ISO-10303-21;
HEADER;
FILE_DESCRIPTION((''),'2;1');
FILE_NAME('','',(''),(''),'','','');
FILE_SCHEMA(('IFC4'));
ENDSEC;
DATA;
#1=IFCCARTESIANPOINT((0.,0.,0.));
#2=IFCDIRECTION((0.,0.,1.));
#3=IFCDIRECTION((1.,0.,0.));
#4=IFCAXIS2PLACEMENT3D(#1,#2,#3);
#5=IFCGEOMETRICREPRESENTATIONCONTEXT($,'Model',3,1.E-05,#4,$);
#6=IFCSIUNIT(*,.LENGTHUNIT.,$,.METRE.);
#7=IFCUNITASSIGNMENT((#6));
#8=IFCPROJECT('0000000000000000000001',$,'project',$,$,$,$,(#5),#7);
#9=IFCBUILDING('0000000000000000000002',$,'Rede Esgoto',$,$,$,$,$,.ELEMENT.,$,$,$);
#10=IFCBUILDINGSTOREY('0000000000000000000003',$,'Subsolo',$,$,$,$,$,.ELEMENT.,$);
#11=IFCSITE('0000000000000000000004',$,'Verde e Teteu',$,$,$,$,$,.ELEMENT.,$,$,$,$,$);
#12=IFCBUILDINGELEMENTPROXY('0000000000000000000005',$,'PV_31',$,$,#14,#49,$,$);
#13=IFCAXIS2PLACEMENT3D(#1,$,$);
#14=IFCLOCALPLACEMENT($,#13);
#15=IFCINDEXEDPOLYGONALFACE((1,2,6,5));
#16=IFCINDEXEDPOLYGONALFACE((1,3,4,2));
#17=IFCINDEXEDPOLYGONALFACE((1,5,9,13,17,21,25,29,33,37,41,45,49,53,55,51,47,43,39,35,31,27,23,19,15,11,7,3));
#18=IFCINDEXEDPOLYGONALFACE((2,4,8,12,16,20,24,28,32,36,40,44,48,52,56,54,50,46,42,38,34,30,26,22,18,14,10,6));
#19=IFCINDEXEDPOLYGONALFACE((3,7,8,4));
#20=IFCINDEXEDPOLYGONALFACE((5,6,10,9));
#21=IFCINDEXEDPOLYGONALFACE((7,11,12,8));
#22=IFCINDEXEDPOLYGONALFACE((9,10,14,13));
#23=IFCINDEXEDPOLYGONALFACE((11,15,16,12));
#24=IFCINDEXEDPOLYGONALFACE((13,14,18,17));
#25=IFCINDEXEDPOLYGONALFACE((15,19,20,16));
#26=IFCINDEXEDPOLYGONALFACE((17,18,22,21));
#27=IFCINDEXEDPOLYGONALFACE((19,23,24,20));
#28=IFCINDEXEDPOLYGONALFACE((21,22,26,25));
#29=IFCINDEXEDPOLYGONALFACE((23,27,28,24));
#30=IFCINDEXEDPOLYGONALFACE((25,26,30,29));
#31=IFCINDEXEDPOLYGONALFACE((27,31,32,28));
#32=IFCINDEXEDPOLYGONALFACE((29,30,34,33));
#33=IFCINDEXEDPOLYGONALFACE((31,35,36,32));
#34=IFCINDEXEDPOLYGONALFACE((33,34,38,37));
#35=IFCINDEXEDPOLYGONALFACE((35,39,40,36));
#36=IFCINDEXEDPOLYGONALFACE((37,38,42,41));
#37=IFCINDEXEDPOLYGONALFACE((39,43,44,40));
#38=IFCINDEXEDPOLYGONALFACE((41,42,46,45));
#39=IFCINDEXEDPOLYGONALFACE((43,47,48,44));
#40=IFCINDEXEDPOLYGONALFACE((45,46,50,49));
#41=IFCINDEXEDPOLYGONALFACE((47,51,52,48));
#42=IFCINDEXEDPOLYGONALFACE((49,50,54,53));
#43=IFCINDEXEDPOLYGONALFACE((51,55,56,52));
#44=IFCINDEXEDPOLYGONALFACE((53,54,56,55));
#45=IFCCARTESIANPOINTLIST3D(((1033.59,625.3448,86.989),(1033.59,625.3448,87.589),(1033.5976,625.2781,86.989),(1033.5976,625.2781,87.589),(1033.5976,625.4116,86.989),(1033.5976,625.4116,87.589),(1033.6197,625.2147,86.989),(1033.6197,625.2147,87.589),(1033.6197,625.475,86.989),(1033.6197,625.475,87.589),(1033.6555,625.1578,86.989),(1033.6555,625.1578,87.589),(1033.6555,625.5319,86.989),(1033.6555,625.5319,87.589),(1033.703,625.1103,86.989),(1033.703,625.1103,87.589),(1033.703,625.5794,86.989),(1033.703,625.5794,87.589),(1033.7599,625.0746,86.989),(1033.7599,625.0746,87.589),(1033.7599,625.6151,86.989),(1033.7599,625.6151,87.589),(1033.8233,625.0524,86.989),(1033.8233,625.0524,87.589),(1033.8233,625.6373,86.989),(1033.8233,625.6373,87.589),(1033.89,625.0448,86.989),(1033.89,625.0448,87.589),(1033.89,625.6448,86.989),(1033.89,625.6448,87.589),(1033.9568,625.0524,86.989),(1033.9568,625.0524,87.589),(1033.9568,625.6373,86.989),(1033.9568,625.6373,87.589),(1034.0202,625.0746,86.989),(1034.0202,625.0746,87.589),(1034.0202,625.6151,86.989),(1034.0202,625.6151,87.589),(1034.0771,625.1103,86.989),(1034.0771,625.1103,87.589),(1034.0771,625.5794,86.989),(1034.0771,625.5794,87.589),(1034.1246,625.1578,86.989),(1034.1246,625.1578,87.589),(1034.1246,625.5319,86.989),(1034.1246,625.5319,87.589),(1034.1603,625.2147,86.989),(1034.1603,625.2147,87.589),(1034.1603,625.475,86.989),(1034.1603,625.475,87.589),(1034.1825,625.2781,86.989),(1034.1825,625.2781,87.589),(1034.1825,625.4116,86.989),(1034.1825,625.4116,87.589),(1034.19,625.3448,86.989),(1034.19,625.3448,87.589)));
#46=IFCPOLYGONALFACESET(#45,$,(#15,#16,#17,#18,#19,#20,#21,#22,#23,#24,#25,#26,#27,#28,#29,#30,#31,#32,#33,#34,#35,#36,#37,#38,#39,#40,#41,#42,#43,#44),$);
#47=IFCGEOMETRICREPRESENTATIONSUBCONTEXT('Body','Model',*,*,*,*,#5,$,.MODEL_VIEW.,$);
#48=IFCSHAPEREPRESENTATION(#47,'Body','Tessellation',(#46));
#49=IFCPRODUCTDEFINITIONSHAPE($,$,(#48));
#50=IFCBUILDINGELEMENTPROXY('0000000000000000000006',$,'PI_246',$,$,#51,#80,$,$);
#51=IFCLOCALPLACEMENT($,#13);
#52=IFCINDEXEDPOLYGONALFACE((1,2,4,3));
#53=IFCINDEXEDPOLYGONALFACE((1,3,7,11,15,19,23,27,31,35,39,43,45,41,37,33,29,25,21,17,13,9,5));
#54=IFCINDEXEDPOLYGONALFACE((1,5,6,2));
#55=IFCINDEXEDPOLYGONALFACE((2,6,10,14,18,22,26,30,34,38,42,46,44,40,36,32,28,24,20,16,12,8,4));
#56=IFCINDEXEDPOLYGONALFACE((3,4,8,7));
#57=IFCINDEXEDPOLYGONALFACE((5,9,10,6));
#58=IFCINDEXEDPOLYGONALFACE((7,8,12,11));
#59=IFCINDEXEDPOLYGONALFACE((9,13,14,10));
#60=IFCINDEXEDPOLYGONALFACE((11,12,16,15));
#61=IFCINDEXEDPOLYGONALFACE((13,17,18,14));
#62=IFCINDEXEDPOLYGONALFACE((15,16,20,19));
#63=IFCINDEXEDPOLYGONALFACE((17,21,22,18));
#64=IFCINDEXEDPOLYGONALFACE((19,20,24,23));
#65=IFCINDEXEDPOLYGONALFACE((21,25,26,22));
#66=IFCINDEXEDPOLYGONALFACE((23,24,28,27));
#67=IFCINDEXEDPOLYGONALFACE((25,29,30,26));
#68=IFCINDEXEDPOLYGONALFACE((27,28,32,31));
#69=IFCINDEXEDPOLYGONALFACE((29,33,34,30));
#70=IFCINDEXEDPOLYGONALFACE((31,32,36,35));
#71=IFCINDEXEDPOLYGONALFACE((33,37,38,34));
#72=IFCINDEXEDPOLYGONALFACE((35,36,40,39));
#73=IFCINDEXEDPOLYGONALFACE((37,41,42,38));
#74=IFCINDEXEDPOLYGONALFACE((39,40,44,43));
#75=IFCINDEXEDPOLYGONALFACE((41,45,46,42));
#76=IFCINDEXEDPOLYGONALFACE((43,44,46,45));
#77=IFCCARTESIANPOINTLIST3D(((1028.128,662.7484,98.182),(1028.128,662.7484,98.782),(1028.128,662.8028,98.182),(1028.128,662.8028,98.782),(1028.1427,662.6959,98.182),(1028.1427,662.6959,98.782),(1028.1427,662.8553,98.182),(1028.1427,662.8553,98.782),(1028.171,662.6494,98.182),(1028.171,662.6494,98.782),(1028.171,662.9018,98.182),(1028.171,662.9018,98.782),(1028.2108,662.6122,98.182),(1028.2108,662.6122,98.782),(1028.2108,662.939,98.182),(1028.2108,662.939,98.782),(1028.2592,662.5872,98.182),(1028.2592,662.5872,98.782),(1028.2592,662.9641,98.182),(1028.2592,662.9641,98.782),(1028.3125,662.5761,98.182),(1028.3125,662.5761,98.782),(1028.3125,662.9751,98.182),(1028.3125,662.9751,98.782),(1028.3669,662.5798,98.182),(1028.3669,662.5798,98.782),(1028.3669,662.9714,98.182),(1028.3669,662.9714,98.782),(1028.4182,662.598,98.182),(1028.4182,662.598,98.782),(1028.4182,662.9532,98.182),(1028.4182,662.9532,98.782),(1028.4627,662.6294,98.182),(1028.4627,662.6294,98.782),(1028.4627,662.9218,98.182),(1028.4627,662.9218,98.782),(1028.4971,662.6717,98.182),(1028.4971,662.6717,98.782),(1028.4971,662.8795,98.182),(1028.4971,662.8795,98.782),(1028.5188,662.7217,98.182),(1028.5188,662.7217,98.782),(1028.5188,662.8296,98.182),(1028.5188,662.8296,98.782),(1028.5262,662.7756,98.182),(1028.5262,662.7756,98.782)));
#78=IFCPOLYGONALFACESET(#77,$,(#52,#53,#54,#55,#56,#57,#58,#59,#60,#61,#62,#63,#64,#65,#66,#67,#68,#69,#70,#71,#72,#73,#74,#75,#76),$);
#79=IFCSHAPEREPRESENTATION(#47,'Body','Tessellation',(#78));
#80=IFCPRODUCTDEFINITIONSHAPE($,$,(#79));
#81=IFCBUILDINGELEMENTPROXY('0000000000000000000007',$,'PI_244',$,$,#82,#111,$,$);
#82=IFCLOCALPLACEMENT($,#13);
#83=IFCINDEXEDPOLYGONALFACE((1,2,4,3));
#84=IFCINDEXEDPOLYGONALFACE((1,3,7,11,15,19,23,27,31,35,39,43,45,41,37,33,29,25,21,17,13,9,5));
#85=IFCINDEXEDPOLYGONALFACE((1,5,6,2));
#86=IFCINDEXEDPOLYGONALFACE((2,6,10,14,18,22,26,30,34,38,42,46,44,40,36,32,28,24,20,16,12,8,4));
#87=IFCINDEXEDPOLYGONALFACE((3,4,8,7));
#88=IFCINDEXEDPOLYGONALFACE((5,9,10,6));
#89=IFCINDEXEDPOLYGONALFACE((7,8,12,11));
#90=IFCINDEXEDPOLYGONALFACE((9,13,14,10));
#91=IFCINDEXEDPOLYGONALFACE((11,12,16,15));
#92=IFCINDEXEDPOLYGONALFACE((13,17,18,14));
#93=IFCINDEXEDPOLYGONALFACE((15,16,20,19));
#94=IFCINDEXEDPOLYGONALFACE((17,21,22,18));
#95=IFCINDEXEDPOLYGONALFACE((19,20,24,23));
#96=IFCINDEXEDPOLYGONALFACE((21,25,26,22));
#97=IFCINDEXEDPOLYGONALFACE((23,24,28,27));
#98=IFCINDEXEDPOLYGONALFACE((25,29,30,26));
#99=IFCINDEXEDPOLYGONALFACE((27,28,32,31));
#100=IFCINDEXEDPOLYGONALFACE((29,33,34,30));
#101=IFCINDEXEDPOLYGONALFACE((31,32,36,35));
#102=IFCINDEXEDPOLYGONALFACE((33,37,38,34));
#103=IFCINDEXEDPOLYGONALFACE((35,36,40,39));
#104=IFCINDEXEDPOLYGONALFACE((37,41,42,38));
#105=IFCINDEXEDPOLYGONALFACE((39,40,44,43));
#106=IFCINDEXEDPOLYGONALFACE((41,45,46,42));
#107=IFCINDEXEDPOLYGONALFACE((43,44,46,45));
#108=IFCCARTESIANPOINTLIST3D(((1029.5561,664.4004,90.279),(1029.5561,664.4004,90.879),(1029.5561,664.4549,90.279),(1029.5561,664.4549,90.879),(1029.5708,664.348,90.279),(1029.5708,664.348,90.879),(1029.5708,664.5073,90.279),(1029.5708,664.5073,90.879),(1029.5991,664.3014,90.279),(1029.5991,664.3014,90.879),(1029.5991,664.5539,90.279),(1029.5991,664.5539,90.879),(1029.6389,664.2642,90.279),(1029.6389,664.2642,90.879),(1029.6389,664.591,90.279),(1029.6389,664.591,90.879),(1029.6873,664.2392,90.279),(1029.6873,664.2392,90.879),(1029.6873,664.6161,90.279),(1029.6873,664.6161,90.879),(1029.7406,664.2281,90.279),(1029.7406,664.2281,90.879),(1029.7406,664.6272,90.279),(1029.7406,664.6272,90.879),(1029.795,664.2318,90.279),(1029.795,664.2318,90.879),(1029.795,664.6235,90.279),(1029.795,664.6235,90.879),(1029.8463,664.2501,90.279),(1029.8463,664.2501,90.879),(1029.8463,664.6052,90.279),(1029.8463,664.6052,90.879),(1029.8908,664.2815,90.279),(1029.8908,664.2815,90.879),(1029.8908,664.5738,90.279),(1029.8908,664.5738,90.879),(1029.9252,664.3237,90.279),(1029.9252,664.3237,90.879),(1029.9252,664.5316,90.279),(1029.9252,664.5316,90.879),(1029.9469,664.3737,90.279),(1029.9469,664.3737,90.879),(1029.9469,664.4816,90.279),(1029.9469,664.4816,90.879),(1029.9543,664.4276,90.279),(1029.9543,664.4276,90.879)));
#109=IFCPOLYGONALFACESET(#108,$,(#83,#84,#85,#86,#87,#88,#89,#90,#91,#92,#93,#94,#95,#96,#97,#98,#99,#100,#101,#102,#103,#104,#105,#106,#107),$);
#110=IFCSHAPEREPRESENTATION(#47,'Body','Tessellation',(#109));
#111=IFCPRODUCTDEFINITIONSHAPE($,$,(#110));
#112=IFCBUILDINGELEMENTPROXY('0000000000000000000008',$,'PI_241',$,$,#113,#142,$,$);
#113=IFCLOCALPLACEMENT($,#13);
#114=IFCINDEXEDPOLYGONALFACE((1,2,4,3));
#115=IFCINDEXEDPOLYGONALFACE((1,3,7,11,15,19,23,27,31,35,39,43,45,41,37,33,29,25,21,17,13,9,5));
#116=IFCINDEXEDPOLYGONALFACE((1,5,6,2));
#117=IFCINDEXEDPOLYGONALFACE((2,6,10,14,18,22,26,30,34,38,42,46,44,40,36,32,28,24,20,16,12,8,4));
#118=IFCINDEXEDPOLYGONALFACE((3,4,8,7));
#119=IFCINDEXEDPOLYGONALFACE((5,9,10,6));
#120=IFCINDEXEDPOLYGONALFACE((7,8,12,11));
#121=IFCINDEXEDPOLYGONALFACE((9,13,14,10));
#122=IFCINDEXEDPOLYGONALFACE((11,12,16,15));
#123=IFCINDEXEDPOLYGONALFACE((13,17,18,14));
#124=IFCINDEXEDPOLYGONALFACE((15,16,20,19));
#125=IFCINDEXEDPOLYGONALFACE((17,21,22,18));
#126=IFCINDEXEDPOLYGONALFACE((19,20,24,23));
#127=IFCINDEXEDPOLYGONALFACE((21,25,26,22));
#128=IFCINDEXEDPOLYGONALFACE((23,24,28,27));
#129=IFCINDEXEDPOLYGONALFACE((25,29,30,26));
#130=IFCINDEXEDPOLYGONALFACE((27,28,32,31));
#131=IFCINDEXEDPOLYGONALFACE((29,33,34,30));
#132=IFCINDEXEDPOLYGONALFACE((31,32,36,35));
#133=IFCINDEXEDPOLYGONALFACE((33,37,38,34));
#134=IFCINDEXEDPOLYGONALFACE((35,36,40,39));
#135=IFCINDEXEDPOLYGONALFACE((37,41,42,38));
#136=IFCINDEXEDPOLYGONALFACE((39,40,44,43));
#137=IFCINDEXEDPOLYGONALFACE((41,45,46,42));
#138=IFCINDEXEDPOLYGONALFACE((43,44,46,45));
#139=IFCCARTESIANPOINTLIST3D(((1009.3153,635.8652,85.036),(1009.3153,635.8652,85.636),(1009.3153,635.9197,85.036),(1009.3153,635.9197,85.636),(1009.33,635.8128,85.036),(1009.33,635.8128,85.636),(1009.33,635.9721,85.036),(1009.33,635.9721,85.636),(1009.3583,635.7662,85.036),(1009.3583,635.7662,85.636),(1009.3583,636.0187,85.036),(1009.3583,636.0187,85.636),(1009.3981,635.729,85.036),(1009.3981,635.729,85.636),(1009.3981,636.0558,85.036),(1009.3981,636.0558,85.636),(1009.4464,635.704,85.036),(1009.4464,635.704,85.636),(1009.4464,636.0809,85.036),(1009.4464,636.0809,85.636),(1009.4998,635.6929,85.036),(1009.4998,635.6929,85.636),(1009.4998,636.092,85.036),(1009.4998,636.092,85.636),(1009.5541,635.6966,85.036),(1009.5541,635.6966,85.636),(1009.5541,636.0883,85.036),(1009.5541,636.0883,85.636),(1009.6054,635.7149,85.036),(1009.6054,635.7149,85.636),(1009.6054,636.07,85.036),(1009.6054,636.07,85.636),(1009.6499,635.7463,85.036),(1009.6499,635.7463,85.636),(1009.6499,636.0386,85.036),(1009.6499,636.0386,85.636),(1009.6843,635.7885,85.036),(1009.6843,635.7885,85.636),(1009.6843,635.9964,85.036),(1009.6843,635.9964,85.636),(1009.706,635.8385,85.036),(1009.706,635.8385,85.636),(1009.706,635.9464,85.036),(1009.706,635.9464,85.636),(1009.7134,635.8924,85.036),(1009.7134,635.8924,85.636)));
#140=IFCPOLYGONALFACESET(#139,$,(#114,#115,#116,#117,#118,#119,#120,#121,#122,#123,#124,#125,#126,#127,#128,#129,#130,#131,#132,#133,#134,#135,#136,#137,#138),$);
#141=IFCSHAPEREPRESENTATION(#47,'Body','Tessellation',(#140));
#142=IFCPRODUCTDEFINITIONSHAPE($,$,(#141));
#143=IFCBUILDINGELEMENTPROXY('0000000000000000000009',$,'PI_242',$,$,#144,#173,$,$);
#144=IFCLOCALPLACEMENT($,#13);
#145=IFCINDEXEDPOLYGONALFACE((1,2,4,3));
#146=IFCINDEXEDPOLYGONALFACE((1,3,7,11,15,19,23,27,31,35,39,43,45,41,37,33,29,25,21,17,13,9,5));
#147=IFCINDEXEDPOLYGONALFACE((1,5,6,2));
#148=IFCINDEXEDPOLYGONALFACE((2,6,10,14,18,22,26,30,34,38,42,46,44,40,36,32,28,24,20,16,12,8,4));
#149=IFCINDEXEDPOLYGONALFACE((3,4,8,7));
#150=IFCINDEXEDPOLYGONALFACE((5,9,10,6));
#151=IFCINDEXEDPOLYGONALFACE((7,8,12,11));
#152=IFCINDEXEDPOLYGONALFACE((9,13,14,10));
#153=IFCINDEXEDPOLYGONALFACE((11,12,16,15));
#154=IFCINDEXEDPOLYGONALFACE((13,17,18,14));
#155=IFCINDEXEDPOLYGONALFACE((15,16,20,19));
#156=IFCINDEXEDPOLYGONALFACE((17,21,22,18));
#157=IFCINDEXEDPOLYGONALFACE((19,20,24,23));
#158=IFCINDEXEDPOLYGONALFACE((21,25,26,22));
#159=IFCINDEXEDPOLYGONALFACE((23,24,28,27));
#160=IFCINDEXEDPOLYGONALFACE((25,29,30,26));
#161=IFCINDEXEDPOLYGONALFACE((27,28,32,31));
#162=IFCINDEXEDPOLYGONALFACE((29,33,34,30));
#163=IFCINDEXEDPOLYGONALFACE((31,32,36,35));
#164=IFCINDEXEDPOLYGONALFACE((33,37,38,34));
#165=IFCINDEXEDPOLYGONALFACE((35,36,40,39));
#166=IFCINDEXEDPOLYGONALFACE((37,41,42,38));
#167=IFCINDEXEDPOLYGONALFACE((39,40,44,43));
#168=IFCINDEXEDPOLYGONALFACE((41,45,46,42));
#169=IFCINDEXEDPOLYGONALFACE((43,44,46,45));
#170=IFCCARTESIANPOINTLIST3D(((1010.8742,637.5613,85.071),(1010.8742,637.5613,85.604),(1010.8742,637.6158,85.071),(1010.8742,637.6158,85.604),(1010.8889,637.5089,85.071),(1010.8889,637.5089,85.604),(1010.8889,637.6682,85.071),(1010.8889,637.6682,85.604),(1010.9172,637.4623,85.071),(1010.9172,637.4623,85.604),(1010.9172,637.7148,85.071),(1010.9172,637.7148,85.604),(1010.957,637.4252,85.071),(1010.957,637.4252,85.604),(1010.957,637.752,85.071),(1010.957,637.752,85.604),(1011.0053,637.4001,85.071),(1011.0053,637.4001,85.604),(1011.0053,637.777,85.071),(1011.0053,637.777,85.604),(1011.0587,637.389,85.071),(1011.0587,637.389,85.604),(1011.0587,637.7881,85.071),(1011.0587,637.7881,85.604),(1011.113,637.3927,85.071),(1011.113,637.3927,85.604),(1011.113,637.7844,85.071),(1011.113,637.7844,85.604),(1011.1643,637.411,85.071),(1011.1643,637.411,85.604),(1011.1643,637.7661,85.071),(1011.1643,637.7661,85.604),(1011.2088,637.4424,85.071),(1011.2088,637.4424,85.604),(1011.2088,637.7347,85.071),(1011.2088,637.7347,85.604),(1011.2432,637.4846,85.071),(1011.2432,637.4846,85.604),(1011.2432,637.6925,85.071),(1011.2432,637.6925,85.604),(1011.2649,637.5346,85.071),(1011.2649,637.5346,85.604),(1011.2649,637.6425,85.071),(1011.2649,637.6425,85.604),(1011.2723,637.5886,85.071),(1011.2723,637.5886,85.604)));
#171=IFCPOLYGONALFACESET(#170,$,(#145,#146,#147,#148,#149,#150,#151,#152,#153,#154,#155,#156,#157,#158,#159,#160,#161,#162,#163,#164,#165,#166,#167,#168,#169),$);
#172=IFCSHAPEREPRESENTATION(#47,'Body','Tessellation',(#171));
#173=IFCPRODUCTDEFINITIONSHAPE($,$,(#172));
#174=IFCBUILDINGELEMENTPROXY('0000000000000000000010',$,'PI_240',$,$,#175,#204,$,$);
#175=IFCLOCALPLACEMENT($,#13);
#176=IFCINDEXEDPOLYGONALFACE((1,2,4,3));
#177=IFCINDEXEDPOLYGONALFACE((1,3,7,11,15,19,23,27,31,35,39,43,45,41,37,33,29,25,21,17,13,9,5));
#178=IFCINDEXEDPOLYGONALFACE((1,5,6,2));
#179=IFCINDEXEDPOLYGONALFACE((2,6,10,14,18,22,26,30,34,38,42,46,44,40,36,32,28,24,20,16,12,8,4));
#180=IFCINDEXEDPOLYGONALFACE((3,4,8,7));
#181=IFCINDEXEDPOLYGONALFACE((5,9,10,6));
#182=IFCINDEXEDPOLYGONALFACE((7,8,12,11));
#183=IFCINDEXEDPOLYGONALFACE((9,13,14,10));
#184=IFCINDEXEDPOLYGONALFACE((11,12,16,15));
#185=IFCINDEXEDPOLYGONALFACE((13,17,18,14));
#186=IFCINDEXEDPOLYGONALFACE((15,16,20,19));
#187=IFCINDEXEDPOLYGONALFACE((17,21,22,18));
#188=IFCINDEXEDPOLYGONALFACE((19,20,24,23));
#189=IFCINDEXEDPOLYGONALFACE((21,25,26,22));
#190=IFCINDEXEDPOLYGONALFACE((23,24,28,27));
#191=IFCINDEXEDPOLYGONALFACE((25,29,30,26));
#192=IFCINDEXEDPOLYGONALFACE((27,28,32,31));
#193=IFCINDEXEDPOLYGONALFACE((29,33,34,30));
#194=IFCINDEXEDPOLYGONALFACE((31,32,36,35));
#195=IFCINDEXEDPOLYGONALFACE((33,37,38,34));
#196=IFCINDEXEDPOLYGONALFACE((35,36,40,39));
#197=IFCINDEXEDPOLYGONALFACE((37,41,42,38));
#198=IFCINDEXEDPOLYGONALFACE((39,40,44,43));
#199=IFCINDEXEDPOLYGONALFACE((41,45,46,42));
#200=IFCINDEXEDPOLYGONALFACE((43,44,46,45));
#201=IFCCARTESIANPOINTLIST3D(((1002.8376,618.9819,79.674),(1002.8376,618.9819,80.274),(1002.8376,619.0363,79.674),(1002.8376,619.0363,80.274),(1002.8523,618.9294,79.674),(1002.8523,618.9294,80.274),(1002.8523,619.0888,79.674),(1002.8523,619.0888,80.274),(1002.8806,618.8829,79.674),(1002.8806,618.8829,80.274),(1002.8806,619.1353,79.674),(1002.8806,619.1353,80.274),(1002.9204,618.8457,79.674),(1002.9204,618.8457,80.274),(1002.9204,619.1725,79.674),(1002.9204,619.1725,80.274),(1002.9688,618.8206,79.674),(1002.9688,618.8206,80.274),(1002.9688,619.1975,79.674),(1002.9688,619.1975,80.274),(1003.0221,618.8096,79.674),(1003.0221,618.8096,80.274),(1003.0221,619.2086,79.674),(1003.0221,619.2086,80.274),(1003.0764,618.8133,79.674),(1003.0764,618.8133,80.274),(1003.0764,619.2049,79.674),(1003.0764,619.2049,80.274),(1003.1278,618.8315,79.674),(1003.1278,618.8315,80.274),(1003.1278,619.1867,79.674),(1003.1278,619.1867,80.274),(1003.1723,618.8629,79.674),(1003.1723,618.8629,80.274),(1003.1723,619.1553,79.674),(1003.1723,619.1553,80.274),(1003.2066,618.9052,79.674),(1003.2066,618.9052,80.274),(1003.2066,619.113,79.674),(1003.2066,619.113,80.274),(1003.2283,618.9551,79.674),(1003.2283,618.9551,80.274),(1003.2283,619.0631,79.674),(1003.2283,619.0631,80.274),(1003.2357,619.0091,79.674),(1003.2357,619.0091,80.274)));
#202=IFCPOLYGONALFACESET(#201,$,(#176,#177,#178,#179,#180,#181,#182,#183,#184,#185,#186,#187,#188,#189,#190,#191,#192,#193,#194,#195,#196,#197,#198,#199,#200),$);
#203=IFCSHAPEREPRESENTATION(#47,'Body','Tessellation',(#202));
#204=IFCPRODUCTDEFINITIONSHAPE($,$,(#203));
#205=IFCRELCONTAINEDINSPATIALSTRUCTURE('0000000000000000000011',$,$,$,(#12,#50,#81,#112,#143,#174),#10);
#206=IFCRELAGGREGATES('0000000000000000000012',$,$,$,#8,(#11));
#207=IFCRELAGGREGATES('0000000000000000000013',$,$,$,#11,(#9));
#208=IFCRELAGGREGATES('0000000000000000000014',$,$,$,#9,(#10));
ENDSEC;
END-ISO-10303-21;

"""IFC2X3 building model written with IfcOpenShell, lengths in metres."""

from ifc_helpers import new_model, si_unit, frame, origin_with_axes, origin_2d, place, context, subcontext, project, spatial, circle, extrude, element, save


model = new_model("IFC2X3")

# Units and contexts
model_context = context("Model", 3, precision=1e-05, world=origin_with_axes())
body_context = subcontext(model_context, "Body", "Model", "MODEL_VIEW")
ifc_project = project(units=[si_unit("LENGTHUNIT", "METRE")], contexts=[model_context])

# Site, building, storey
site = spatial("IfcSite", under=ifc_project, Name="Verde e Teteu", CompositionType="ELEMENT")
building = spatial("IfcBuilding", under=site, Name="Rede Esgoto", CompositionType="ELEMENT")
storey = spatial("IfcBuildingStorey", under=building, Name="Subsolo", CompositionType="ELEMENT")

# Building element proxies
proxy_1_placement = place(None, frame((1033.89, 625.3448, 86.989), z_axis=(0.0, 0.0, 1.0), x_axis=(1.0, 0.0, 0.0)))
element("IfcBuildingElementProxy", 1, at=proxy_1_placement, inside=storey, Name="PV_31", context=body_context, shape_type="SweptSolid", body=[
    extrude(circle(Radius=0.3, at=origin_2d()), origin_with_axes(), (0.0, 0.0, 1.0), 0.6),
])
proxy_2_placement = place(None, frame((1028.3262, 662.7756, 98.182), z_axis=(0.0, 0.0, 1.0), x_axis=(1.0, 0.0, 0.0)))
element("IfcBuildingElementProxy", 2, at=proxy_2_placement, inside=storey, Name="PI_246", context=body_context, shape_type="SweptSolid", body=[
    extrude(circle(Radius=0.2, at=origin_2d()), origin_with_axes(), (0.0, 0.0, 1.0), 0.6),
])
proxy_3_placement = place(None, frame((1029.7543, 664.4276, 90.279), z_axis=(0.0, 0.0, 1.0), x_axis=(1.0, 0.0, 0.0)))
element("IfcBuildingElementProxy", 3, at=proxy_3_placement, inside=storey, Name="PI_244", context=body_context, shape_type="SweptSolid", body=[
    extrude(circle(Radius=0.2, at=origin_2d()), origin_with_axes(), (0.0, 0.0, 1.0), 0.6),
])
proxy_4_placement = place(None, frame((1009.5134, 635.8924, 85.036), z_axis=(0.0, 0.0, 1.0), x_axis=(1.0, 0.0, 0.0)))
element("IfcBuildingElementProxy", 4, at=proxy_4_placement, inside=storey, Name="PI_241", context=body_context, shape_type="SweptSolid", body=[
    extrude(circle(Radius=0.2, at=origin_2d()), origin_with_axes(), (0.0, 0.0, 1.0), 0.6),
])
proxy_5_placement = place(None, frame((1011.0723, 637.5886, 85.071), z_axis=(0.0, 0.0, 1.0), x_axis=(1.0, 0.0, 0.0)))
element("IfcBuildingElementProxy", 5, at=proxy_5_placement, inside=storey, Name="PI_242", context=body_context, shape_type="SweptSolid", body=[
    extrude(circle(Radius=0.2, at=origin_2d()), origin_with_axes(), (0.0, 0.0, 1.0), 0.533),
])
for number, where, z_axis, x_axis, name in (
    (6, (1003.0357, 619.0091, 79.674), (0.0, 0.0, 1.0), (1.0, 0.0, 0.0), "PI_240"),
):
    element("IfcBuildingElementProxy", number, at=place(None, frame(where, z_axis=z_axis, x_axis=x_axis)), inside=storey, Name=name, context=body_context, shape_type="SweptSolid", body=[
        extrude(circle(Radius=0.2, at=origin_2d()), origin_with_axes(), (0.0, 0.0, 1.0), 0.6),
    ])

save(model, "model.ifc")
